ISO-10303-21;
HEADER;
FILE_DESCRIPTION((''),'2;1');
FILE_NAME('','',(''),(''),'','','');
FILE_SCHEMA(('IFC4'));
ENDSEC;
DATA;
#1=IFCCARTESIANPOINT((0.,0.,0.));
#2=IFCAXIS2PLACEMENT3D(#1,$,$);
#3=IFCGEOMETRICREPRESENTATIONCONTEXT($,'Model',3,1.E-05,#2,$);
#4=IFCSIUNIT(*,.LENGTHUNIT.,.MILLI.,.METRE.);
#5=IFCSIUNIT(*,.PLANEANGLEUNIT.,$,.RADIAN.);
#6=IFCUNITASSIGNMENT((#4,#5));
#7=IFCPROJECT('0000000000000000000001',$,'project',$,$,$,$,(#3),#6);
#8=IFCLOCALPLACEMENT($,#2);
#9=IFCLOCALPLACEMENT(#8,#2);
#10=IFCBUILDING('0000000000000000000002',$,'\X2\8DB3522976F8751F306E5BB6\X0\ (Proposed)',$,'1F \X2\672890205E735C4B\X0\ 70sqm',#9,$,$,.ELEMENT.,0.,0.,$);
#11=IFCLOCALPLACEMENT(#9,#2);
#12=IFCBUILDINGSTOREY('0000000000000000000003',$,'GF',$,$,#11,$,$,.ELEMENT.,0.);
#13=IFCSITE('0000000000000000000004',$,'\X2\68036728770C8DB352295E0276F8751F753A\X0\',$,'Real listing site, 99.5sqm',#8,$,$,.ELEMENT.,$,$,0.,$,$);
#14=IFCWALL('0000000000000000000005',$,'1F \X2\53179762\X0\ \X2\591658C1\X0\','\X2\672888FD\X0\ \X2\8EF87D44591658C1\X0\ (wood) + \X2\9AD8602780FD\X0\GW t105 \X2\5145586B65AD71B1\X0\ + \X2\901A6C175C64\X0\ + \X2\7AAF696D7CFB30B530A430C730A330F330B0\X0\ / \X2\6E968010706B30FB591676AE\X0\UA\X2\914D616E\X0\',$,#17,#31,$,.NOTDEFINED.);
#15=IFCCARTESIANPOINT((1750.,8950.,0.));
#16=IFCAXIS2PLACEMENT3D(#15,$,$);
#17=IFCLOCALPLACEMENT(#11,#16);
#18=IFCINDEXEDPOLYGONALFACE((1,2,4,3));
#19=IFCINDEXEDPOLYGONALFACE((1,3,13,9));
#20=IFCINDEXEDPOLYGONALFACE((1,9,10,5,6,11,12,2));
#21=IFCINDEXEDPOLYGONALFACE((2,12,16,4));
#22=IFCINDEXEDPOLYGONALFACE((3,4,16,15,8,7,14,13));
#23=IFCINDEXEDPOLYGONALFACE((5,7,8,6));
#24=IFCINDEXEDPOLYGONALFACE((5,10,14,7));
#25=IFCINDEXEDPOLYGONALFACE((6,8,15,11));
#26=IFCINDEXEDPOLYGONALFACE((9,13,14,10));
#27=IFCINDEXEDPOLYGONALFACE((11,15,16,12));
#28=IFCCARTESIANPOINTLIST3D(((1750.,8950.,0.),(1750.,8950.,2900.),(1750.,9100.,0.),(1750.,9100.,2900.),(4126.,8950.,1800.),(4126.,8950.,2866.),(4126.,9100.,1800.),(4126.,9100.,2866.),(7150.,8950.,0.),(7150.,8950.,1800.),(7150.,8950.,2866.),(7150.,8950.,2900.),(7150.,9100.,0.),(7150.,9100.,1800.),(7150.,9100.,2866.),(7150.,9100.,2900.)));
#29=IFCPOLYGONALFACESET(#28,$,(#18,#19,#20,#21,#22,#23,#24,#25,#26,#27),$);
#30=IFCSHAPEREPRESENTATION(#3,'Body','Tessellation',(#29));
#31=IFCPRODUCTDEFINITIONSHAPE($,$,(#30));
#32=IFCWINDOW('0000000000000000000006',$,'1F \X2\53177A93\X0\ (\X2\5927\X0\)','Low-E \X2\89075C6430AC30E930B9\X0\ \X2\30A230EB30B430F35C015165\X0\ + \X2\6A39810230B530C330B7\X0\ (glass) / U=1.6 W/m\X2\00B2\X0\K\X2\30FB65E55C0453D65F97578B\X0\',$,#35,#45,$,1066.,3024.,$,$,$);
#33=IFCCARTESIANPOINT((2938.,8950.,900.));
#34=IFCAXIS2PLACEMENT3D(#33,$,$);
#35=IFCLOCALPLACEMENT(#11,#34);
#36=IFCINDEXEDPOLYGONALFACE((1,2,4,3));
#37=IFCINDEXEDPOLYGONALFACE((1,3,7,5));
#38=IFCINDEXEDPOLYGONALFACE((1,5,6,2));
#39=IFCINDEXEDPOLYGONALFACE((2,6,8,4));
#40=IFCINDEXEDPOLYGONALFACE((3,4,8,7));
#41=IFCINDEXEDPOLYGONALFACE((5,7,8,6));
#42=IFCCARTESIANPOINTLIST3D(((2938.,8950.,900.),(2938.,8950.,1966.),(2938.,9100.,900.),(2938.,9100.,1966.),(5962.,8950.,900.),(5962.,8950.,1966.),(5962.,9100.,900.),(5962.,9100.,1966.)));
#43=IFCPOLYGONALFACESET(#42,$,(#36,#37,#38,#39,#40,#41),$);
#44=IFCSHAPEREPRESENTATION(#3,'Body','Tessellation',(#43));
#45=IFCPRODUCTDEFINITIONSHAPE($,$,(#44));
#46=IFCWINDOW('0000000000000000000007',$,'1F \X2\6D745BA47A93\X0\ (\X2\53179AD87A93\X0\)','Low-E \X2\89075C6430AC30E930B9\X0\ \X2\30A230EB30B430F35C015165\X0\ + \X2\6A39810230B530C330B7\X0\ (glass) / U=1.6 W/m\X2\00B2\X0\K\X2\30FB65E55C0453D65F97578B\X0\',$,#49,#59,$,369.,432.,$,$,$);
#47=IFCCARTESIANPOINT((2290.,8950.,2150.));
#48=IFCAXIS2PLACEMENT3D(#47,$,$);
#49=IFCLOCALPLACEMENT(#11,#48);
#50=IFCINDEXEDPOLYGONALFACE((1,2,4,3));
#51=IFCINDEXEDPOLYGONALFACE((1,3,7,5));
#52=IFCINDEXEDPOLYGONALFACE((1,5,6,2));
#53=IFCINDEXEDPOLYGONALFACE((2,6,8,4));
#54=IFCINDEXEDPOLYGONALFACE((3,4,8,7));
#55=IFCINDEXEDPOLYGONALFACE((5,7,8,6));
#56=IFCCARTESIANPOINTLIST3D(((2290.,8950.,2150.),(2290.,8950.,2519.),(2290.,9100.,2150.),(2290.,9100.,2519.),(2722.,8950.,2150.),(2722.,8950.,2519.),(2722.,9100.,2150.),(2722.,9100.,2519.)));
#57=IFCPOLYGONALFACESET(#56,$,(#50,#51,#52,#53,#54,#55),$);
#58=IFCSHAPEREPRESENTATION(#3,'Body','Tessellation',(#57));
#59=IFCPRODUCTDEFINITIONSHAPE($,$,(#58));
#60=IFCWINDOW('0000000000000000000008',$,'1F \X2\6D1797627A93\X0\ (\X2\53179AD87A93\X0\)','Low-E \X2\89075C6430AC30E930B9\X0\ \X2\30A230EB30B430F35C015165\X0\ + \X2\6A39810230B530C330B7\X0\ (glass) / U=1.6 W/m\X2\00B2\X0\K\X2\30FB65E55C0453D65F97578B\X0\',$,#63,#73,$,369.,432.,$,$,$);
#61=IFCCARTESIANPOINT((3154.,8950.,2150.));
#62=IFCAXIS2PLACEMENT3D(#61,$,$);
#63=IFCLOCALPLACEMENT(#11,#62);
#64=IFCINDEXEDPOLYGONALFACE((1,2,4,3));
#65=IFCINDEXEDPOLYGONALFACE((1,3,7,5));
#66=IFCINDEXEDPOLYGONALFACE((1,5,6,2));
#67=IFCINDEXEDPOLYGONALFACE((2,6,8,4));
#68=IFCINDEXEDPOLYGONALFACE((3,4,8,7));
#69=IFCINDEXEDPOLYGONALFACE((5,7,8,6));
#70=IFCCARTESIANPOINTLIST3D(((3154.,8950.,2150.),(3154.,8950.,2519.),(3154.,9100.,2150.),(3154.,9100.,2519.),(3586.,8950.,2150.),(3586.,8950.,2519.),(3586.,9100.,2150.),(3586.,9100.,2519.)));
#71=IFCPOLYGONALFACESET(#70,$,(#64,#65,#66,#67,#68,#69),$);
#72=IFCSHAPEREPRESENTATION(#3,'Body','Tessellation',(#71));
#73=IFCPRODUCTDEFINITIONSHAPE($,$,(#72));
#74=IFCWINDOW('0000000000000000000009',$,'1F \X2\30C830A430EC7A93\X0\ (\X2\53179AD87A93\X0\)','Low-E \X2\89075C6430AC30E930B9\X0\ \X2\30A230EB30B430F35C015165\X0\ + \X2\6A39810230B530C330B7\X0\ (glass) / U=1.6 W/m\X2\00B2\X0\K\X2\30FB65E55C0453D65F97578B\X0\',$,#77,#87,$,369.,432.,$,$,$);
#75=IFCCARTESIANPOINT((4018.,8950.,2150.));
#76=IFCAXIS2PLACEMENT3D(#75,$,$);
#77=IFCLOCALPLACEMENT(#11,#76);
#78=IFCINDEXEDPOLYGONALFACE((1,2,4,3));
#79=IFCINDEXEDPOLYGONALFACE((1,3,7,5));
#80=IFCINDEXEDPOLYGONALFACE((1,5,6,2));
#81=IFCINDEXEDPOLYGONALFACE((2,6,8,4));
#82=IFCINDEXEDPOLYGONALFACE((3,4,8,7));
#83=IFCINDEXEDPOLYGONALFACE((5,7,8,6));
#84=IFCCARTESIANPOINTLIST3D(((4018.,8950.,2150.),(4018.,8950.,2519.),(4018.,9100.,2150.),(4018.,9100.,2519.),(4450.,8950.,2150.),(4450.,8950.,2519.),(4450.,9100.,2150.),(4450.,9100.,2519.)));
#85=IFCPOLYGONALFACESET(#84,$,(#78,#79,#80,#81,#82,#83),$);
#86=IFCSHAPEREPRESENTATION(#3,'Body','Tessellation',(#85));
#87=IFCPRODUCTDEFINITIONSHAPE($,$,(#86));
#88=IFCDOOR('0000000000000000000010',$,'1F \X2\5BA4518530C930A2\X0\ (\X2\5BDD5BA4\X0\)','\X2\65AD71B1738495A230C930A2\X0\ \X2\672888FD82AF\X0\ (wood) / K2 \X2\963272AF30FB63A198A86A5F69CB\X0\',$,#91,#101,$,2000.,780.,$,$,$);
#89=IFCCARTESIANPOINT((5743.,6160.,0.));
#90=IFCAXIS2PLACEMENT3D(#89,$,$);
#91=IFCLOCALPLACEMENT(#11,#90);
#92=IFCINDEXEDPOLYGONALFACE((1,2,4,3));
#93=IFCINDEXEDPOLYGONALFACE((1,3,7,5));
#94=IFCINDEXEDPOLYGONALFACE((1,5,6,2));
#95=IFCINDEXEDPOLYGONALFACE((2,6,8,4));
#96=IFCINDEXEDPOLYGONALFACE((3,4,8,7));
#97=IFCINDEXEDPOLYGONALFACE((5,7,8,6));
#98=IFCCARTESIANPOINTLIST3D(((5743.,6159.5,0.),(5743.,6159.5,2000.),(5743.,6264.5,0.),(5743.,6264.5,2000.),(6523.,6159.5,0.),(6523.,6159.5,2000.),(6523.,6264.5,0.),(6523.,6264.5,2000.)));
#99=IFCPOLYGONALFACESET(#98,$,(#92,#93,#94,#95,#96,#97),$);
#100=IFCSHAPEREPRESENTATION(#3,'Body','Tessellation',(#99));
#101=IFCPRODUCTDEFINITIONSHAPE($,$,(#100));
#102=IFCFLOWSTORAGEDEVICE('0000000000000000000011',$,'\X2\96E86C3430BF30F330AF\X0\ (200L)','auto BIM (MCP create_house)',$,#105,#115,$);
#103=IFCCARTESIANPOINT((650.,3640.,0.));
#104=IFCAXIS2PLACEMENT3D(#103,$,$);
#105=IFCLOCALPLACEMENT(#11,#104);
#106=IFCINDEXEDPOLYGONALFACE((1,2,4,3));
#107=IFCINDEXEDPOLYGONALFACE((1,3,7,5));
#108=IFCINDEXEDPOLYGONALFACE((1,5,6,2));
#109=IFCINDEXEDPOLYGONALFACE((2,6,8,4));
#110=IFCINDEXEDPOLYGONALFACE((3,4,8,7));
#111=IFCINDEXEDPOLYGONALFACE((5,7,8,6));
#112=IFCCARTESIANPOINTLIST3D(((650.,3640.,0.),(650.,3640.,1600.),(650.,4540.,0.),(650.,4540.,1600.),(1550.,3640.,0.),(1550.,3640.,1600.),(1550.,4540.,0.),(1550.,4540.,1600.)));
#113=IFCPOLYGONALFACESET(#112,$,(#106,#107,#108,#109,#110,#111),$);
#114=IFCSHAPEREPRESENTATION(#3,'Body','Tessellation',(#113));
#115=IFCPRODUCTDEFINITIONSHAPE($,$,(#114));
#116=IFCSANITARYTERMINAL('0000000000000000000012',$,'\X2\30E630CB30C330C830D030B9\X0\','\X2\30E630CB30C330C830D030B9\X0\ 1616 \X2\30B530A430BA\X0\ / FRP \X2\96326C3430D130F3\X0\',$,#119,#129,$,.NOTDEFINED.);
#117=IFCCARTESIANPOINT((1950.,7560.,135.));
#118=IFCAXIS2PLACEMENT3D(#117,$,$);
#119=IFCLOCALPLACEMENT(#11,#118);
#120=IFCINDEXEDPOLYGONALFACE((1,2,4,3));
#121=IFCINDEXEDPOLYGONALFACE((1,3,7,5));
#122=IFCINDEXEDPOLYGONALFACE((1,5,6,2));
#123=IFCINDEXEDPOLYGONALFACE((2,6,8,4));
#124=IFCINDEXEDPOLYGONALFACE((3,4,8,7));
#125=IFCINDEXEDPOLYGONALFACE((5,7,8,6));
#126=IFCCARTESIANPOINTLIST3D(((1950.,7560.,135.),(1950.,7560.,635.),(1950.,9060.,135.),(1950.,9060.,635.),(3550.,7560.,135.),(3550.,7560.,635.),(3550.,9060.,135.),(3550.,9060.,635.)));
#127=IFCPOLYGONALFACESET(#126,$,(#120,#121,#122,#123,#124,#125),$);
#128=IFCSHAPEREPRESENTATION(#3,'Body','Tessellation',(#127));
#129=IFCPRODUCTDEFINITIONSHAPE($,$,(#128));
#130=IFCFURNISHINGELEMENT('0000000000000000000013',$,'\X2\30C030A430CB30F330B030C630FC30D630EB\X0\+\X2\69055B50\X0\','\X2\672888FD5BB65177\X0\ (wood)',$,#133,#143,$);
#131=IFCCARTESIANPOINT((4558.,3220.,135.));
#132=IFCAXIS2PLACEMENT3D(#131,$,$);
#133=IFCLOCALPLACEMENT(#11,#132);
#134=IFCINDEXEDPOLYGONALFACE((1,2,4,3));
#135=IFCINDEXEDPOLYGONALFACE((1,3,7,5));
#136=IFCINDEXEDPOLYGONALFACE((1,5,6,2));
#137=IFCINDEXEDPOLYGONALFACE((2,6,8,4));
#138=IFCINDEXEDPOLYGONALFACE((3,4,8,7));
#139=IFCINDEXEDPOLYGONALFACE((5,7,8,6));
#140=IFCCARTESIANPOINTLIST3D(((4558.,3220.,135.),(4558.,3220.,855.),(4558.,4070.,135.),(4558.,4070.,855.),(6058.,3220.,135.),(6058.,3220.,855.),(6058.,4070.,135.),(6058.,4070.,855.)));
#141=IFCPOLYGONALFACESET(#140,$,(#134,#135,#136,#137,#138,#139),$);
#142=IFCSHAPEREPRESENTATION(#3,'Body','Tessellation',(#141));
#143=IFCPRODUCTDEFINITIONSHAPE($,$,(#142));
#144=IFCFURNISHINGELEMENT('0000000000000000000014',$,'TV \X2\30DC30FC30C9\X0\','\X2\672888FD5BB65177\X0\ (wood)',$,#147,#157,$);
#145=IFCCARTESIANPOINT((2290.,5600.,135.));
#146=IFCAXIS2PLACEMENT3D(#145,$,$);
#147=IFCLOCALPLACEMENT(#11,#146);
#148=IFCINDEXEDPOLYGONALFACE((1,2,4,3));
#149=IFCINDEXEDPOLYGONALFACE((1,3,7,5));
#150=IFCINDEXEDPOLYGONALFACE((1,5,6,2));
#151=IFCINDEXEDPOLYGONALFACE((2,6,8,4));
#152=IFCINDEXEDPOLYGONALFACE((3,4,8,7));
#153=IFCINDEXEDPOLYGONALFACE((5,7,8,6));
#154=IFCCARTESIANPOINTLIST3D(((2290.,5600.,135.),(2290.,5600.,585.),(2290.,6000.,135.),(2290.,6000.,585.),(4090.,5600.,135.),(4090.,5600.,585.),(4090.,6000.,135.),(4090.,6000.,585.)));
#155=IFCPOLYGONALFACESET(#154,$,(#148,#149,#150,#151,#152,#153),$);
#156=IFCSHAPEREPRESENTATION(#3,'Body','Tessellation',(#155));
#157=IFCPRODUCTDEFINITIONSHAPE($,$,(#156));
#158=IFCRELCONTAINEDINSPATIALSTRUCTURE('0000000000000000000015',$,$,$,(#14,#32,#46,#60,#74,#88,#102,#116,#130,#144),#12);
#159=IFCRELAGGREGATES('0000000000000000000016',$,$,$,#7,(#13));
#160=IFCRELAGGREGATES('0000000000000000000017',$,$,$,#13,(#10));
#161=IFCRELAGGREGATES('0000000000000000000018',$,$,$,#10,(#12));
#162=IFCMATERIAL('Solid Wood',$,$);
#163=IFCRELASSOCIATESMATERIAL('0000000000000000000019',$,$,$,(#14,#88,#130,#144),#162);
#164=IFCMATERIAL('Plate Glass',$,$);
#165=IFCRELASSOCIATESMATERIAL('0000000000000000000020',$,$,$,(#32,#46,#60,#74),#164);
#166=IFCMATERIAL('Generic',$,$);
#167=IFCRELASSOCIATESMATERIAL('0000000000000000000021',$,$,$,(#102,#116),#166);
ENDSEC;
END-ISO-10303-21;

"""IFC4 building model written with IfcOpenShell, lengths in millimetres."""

from ifc_helpers import new_model, si_unit, frame, frame_2d, origin, place, context, project, spatial, rectangle, extrude, material, element, fill, save


model = new_model("IFC4")

# Units and contexts
model_context = context("Model", 3, precision=1e-05, world=origin())
ifc_project = project(units=[si_unit("LENGTHUNIT", "METRE", prefix="MILLI"), si_unit("PLANEANGLEUNIT", "RADIAN")], contexts=[model_context])

# Site, building, storey
site_placement = place(None, origin())
site = spatial("IfcSite", under=ifc_project, at=site_placement, Name="栃木県足利市相生町", ObjectType="Real listing site, 99.5sqm", CompositionType="ELEMENT", RefElevation=0.0)
building_placement = place(site_placement, origin())
building = spatial("IfcBuilding", under=site, at=building_placement, Name="足利相生の家 (Proposed)", ObjectType="1F 木造平屋 70sqm", CompositionType="ELEMENT", ElevationOfRefHeight=0.0, ElevationOfTerrain=0.0)
storey_placement = place(building_placement, origin())
storey = spatial("IfcBuildingStorey", under=building, at=storey_placement, Name="GF", CompositionType="ELEMENT", Elevation=0.0)

# Wall, openings, windows
ifc_material_1 = material(Name="Solid Wood")
wall_1_placement = place(storey_placement, frame((1750.0, 8950.0, 0.0)))
wall_1 = element("IfcWall", 1, at=wall_1_placement, inside=storey, material=ifc_material_1, Name="1F 北面 外壁", Description="木製 軸組外壁 (wood) + 高性能GW t105 充填断熱 + 通気層 + 窯業系サイディング / 準耐火・外皮UA配慮", PredefinedType="NOTDEFINED", context=model_context, shape_type="SweptSolid", body=[
    extrude(rectangle(XDim=5400.0, YDim=150.0, at=frame_2d((2700.0, 75.0))), frame((1750.0, 8950.0, 0.0)), (0.0, 0.0, 1.0), 2900.0),
])
opening_1_placement = place(storey_placement, frame((2938.0, 8950.0, 900.0)))
opening_1 = element("IfcOpeningElement", 2, at=opening_1_placement, cuts=wall_1, PredefinedType="NOTDEFINED", context=model_context, shape_type="SweptSolid", body=[
    extrude(rectangle(XDim=3024.0, YDim=150.0, at=frame_2d((1512.0, 75.0))), frame((2938.0, 8950.0, 900.0)), (0.0, 0.0, 1.0), 1066.0),
])
opening_2_placement = place(storey_placement, frame((2290.0, 8950.0, 2150.0)))
opening_2 = element("IfcOpeningElement", 3, at=opening_2_placement, cuts=wall_1, PredefinedType="NOTDEFINED", context=model_context, shape_type="SweptSolid", body=[
    extrude(rectangle(XDim=432.0, YDim=150.0, at=frame_2d((216.0, 75.0))), frame((2290.0, 8950.0, 2150.0)), (0.0, 0.0, 1.0), 369.0),
])
opening_3_placement = place(storey_placement, frame((3154.0, 8950.0, 2150.0)))
opening_3 = element("IfcOpeningElement", 4, at=opening_3_placement, cuts=wall_1, PredefinedType="NOTDEFINED", context=model_context, shape_type="SweptSolid", body=[
    extrude(rectangle(XDim=432.0, YDim=150.0, at=frame_2d((216.0, 75.0))), frame((3154.0, 8950.0, 2150.0)), (0.0, 0.0, 1.0), 369.0),
])
opening_4_placement = place(storey_placement, frame((4018.0, 8950.0, 2150.0)))
opening_4 = element("IfcOpeningElement", 5, at=opening_4_placement, cuts=wall_1, PredefinedType="NOTDEFINED", context=model_context, shape_type="SweptSolid", body=[
    extrude(rectangle(XDim=432.0, YDim=150.0, at=frame_2d((216.0, 75.0))), frame((4018.0, 8950.0, 2150.0)), (0.0, 0.0, 1.0), 369.0),
])
ifc_material_2 = material(Name="Plate Glass")
window_1_placement = place(storey_placement, frame((2938.0, 8950.0, 900.0)))
window_1 = element("IfcWindow", 6, at=window_1_placement, inside=storey, material=ifc_material_2, Name="1F 北窓 (大)", Description="Low-E 複層ガラス アルゴン封入 + 樹脂サッシ (glass) / U=1.6 W/m²K・日射取得型", OverallHeight=1066.0, OverallWidth=3024.0, context=model_context, shape_type="SweptSolid", body=[
    extrude(rectangle(XDim=3024.0, YDim=150.0, at=frame_2d((1512.0, 75.0))), frame((2938.0, 8950.0, 900.0)), (0.0, 0.0, 1.0), 1066.0),
])
fill(opening_1, window_1)
window_2_placement = place(storey_placement, frame((2290.0, 8950.0, 2150.0)))
window_2 = element("IfcWindow", 7, at=window_2_placement, inside=storey, material=ifc_material_2, Name="1F 浴室窓 (北高窓)", Description="Low-E 複層ガラス アルゴン封入 + 樹脂サッシ (glass) / U=1.6 W/m²K・日射取得型", OverallHeight=369.0, OverallWidth=432.0, context=model_context, shape_type="SweptSolid", body=[
    extrude(rectangle(XDim=432.0, YDim=150.0, at=frame_2d((216.0, 75.0))), frame((2290.0, 8950.0, 2150.0)), (0.0, 0.0, 1.0), 369.0),
])
fill(opening_2, window_2)
window_3_placement = place(storey_placement, frame((3154.0, 8950.0, 2150.0)))
window_3 = element("IfcWindow", 8, at=window_3_placement, inside=storey, material=ifc_material_2, Name="1F 洗面窓 (北高窓)", Description="Low-E 複層ガラス アルゴン封入 + 樹脂サッシ (glass) / U=1.6 W/m²K・日射取得型", OverallHeight=369.0, OverallWidth=432.0, context=model_context, shape_type="SweptSolid", body=[
    extrude(rectangle(XDim=432.0, YDim=150.0, at=frame_2d((216.0, 75.0))), frame((3154.0, 8950.0, 2150.0)), (0.0, 0.0, 1.0), 369.0),
])
fill(opening_3, window_3)
window_4_placement = place(storey_placement, frame((4018.0, 8950.0, 2150.0)))
window_4 = element("IfcWindow", 9, at=window_4_placement, inside=storey, material=ifc_material_2, Name="1F トイレ窓 (北高窓)", Description="Low-E 複層ガラス アルゴン封入 + 樹脂サッシ (glass) / U=1.6 W/m²K・日射取得型", OverallHeight=369.0, OverallWidth=432.0, context=model_context, shape_type="SweptSolid", body=[
    extrude(rectangle(XDim=432.0, YDim=150.0, at=frame_2d((216.0, 75.0))), frame((4018.0, 8950.0, 2150.0)), (0.0, 0.0, 1.0), 369.0),
])
fill(opening_4, window_4)

# Door
door_1_placement = place(storey_placement, frame((5743.0, 6160.0, 0.0)))
element("IfcDoor", 10, at=door_1_placement, inside=storey, material=ifc_material_1, Name="1F 室内ドア (寝室)", Description="断熱玄関ドア 木製芯 (wood) / K2 防犯・採風機構", OverallHeight=2000.0, OverallWidth=780.0, context=model_context, shape_type="SweptSolid", body=[
    extrude(rectangle(XDim=780.0, YDim=105.0, at=frame_2d((390.0, 52.0))), frame((5743.0, 6160.0, 0.0)), (0.0, 0.0, 1.0), 2000.0),
])

# Flow storage device
ifc_material_3 = material(Name="Generic")
flow_storage_device_placement = place(storey_placement, frame((650.0, 3640.0, 0.0)))
element("IfcFlowStorageDevice", 11, at=flow_storage_device_placement, inside=storey, material=ifc_material_3, Name="雨水タンク (200L)", Description="auto BIM (MCP create_house)", context=model_context, shape_type="SweptSolid", body=[
    extrude(rectangle(XDim=900.0, YDim=900.0, at=frame_2d((450.0, 450.0))), frame((650.0, 3640.0, 0.0)), (0.0, 0.0, 1.0), 1600.0),
])

# Sanitary terminal
sanitary_terminal_placement = place(storey_placement, frame((1950.0, 7560.0, 135.0)))
element("IfcSanitaryTerminal", 12, at=sanitary_terminal_placement, inside=storey, material=ifc_material_3, Name="ユニットバス", Description="ユニットバス 1616 サイズ / FRP 防水パン", PredefinedType="NOTDEFINED", context=model_context, shape_type="SweptSolid", body=[
    extrude(rectangle(XDim=1600.0, YDim=1500.0, at=frame_2d((800.0, 750.0))), frame((1950.0, 7560.0, 135.0)), (0.0, 0.0, 1.0), 500.0),
])

# Furnishing elements
furnishing_1_placement = place(storey_placement, frame((4558.0, 3220.0, 135.0)))
element("IfcFurnishingElement", 13, at=furnishing_1_placement, inside=storey, material=ifc_material_1, Name="ダイニングテーブル+椅子", Description="木製家具 (wood)", context=model_context, shape_type="SweptSolid", body=[
    extrude(rectangle(XDim=1500.0, YDim=850.0, at=frame_2d((750.0, 425.0))), frame((4558.0, 3220.0, 135.0)), (0.0, 0.0, 1.0), 720.0),
])
furnishing_2_placement = place(storey_placement, frame((2290.0, 5600.0, 135.0)))
element("IfcFurnishingElement", 14, at=furnishing_2_placement, inside=storey, material=ifc_material_1, Name="TV ボード", Description="木製家具 (wood)", context=model_context, shape_type="SweptSolid", body=[
    extrude(rectangle(XDim=1800.0, YDim=400.0, at=frame_2d((900.0, 200.0))), frame((2290.0, 5600.0, 135.0)), (0.0, 0.0, 1.0), 450.0),
])

save(model, "model.ifc")
